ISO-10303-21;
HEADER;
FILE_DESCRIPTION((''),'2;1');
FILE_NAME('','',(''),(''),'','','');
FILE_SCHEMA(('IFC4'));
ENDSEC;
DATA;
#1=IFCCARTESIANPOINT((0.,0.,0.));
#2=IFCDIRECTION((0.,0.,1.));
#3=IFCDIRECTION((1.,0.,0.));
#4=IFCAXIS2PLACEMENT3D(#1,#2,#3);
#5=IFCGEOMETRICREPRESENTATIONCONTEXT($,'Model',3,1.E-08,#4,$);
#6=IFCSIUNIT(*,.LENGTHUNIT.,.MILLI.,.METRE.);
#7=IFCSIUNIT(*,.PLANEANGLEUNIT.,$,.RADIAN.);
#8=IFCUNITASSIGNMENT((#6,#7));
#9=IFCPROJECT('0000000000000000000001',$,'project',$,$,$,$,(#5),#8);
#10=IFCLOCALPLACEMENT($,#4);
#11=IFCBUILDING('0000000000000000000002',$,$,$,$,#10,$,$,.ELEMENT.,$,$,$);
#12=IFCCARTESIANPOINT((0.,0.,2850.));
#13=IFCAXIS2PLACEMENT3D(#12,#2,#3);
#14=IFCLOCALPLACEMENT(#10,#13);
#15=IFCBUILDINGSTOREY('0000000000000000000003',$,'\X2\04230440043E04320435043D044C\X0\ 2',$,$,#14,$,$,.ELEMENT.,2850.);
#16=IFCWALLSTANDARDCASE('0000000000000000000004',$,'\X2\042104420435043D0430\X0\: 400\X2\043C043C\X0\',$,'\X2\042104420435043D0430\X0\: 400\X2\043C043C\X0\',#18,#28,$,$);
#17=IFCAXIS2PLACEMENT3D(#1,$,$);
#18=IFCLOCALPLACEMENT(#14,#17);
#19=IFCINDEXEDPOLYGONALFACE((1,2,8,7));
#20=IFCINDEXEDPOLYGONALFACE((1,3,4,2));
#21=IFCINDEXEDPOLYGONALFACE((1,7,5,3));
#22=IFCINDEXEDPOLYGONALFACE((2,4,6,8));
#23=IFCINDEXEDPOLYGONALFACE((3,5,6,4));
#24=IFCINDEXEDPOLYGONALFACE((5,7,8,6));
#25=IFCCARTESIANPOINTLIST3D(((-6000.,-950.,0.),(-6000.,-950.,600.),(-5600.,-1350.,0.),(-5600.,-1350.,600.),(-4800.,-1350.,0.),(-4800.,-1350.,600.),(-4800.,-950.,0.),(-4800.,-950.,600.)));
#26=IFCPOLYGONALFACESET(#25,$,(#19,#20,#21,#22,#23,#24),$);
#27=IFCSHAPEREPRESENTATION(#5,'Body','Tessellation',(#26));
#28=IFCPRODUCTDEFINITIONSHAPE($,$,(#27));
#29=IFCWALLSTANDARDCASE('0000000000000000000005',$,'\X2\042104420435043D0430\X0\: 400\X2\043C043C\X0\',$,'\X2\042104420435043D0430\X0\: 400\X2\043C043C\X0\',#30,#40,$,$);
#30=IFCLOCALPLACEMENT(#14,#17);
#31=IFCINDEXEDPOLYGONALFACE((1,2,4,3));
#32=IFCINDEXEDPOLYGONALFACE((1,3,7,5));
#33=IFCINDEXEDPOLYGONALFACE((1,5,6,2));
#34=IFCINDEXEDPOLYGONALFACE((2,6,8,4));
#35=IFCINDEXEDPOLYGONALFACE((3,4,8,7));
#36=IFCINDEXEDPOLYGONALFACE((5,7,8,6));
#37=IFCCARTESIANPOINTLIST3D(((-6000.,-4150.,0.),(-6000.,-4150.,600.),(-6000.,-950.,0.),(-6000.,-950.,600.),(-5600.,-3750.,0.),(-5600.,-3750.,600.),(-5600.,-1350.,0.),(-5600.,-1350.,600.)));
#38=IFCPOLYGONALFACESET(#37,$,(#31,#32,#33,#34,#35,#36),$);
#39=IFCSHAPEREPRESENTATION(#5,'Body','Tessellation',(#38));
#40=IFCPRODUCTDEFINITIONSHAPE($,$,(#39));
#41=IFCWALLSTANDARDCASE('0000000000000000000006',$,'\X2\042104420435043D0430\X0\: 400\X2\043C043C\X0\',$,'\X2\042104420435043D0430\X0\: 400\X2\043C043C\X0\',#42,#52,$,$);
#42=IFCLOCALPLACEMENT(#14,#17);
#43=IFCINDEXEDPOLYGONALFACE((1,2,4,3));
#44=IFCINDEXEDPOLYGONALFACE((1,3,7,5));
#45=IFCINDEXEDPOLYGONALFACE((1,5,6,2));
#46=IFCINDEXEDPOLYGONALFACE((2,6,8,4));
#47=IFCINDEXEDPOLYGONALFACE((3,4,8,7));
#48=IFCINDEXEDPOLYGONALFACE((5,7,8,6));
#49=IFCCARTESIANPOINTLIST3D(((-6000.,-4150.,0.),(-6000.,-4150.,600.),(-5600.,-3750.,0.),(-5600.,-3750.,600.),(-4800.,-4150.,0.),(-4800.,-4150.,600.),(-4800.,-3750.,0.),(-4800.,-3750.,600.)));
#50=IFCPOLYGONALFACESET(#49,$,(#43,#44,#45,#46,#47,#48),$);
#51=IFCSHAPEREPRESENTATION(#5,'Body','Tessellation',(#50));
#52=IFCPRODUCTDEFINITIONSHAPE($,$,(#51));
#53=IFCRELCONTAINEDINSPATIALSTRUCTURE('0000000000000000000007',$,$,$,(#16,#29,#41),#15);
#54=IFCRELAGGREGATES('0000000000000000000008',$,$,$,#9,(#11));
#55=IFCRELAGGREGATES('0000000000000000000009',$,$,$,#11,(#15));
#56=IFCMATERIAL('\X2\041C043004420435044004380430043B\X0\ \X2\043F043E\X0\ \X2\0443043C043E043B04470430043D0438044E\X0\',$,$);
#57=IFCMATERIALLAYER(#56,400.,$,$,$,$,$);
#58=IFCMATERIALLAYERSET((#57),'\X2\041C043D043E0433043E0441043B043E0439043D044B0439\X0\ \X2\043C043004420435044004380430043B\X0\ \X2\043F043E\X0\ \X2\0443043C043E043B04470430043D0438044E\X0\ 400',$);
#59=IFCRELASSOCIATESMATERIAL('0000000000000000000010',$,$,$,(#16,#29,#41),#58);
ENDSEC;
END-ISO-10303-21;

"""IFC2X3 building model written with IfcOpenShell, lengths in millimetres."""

from ifc_helpers import new_model, si_unit, frame, origin_with_axes, place, context, project, spatial, polyline, segment, composite_curve, outline, extrude, material, layer, layer_set, layer_usage, element, save


model = new_model("IFC2X3")

# Units and contexts
model_context = context("Model", 3, precision=1e-08, world=origin_with_axes())
ifc_project = project(units=[si_unit("LENGTHUNIT", "METRE", prefix="MILLI"), si_unit("PLANEANGLEUNIT", "RADIAN")], contexts=[model_context])

# Building, storey
building_placement = place(None, origin_with_axes())
building = spatial("IfcBuilding", under=ifc_project, at=building_placement, CompositionType="ELEMENT")
storey_placement = place(building_placement, frame((0.0, 0.0, 2850.0), z_axis=(0.0, 0.0, 1.0), x_axis=(1.0, 0.0, 0.0)))
storey = spatial("IfcBuildingStorey", under=building, at=storey_placement, Name="Уровень 2", CompositionType="ELEMENT", Elevation=2850.0)

# Walls
ifc_material_1 = material(Name="Материал по умолчанию")
ifc_layer_1 = layer(ifc_material_1, 400.0)
ifc_layer_set_1 = layer_set([ifc_layer_1], Name="Многослойный материал по умолчанию 400")
ifc_layer_usage_1 = layer_usage(ifc_layer_set_1, "AXIS2", "NEGATIVE", 400.0)
wall_1_placement = place(storey_placement, frame((-4800.0, -950.0, 0.0), z_axis=(0.0, 0.0, 1.0), x_axis=(-1.0, 0.0, 0.0)))
element("IfcWallStandardCase", 1, at=wall_1_placement, inside=storey, material=ifc_layer_usage_1, Name="Стена: 400мм", ObjectType="Стена: 400мм", context=model_context, shape_type="SweptSolid", body=[
    extrude(outline(composite_curve([segment(polyline([(0.0, 0.0), (1200.0, 0.0)]), True, "CONTINUOUS"), segment(polyline([(1200.0, 0.0), (800.0, 400.0)]), True, "CONTINUOUS"), segment(polyline([(800.0, 400.0), (0.0, 400.0)]), True, "CONTINUOUS"), segment(polyline([(0.0, 400.0), (0.0, 0.0)]), True, "CONTINUOUS")], self_intersect=False)), origin_with_axes(), (0.0, 0.0, 1.0), 600.0),
])
ifc_layer_usage_2 = layer_usage(ifc_layer_set_1, "AXIS2", "NEGATIVE", 400.0)
wall_2_placement = place(storey_placement, frame((-6000.0, -950.0, 0.0), z_axis=(0.0, 0.0, 1.0), x_axis=(0.0, -1.0, 0.0)))
element("IfcWallStandardCase", 2, at=wall_2_placement, inside=storey, material=ifc_layer_usage_2, Name="Стена: 400мм", ObjectType="Стена: 400мм", context=model_context, shape_type="SweptSolid", body=[
    extrude(outline(composite_curve([segment(polyline([(0.0, 0.0), (3200.0, 0.0)]), True, "CONTINUOUS"), segment(polyline([(3200.0, 0.0), (2800.0, 400.0)]), True, "CONTINUOUS"), segment(polyline([(2800.0, 400.0), (400.0, 400.0)]), True, "CONTINUOUS"), segment(polyline([(400.0, 400.0), (0.0, 0.0)]), True, "CONTINUOUS")], self_intersect=False)), origin_with_axes(), (0.0, 0.0, 1.0), 600.0),
])
ifc_layer_usage_3 = layer_usage(ifc_layer_set_1, "AXIS2", "NEGATIVE", 400.0)
wall_3_placement = place(storey_placement, frame((-6000.0, -4150.0, 0.0), z_axis=(0.0, 0.0, 1.0), x_axis=(1.0, 0.0, 0.0)))
element("IfcWallStandardCase", 3, at=wall_3_placement, inside=storey, material=ifc_layer_usage_3, Name="Стена: 400мм", ObjectType="Стена: 400мм", context=model_context, shape_type="SweptSolid", body=[
    extrude(outline(composite_curve([segment(polyline([(0.0, 0.0), (1200.0, 0.0)]), True, "CONTINUOUS"), segment(polyline([(1200.0, 0.0), (1200.0, 400.0)]), True, "CONTINUOUS"), segment(polyline([(1200.0, 400.0), (400.0, 400.0)]), True, "CONTINUOUS"), segment(polyline([(400.0, 400.0), (0.0, 0.0)]), True, "CONTINUOUS")], self_intersect=False)), origin_with_axes(), (0.0, 0.0, 1.0), 600.0),
])

save(model, "model.ifc")
